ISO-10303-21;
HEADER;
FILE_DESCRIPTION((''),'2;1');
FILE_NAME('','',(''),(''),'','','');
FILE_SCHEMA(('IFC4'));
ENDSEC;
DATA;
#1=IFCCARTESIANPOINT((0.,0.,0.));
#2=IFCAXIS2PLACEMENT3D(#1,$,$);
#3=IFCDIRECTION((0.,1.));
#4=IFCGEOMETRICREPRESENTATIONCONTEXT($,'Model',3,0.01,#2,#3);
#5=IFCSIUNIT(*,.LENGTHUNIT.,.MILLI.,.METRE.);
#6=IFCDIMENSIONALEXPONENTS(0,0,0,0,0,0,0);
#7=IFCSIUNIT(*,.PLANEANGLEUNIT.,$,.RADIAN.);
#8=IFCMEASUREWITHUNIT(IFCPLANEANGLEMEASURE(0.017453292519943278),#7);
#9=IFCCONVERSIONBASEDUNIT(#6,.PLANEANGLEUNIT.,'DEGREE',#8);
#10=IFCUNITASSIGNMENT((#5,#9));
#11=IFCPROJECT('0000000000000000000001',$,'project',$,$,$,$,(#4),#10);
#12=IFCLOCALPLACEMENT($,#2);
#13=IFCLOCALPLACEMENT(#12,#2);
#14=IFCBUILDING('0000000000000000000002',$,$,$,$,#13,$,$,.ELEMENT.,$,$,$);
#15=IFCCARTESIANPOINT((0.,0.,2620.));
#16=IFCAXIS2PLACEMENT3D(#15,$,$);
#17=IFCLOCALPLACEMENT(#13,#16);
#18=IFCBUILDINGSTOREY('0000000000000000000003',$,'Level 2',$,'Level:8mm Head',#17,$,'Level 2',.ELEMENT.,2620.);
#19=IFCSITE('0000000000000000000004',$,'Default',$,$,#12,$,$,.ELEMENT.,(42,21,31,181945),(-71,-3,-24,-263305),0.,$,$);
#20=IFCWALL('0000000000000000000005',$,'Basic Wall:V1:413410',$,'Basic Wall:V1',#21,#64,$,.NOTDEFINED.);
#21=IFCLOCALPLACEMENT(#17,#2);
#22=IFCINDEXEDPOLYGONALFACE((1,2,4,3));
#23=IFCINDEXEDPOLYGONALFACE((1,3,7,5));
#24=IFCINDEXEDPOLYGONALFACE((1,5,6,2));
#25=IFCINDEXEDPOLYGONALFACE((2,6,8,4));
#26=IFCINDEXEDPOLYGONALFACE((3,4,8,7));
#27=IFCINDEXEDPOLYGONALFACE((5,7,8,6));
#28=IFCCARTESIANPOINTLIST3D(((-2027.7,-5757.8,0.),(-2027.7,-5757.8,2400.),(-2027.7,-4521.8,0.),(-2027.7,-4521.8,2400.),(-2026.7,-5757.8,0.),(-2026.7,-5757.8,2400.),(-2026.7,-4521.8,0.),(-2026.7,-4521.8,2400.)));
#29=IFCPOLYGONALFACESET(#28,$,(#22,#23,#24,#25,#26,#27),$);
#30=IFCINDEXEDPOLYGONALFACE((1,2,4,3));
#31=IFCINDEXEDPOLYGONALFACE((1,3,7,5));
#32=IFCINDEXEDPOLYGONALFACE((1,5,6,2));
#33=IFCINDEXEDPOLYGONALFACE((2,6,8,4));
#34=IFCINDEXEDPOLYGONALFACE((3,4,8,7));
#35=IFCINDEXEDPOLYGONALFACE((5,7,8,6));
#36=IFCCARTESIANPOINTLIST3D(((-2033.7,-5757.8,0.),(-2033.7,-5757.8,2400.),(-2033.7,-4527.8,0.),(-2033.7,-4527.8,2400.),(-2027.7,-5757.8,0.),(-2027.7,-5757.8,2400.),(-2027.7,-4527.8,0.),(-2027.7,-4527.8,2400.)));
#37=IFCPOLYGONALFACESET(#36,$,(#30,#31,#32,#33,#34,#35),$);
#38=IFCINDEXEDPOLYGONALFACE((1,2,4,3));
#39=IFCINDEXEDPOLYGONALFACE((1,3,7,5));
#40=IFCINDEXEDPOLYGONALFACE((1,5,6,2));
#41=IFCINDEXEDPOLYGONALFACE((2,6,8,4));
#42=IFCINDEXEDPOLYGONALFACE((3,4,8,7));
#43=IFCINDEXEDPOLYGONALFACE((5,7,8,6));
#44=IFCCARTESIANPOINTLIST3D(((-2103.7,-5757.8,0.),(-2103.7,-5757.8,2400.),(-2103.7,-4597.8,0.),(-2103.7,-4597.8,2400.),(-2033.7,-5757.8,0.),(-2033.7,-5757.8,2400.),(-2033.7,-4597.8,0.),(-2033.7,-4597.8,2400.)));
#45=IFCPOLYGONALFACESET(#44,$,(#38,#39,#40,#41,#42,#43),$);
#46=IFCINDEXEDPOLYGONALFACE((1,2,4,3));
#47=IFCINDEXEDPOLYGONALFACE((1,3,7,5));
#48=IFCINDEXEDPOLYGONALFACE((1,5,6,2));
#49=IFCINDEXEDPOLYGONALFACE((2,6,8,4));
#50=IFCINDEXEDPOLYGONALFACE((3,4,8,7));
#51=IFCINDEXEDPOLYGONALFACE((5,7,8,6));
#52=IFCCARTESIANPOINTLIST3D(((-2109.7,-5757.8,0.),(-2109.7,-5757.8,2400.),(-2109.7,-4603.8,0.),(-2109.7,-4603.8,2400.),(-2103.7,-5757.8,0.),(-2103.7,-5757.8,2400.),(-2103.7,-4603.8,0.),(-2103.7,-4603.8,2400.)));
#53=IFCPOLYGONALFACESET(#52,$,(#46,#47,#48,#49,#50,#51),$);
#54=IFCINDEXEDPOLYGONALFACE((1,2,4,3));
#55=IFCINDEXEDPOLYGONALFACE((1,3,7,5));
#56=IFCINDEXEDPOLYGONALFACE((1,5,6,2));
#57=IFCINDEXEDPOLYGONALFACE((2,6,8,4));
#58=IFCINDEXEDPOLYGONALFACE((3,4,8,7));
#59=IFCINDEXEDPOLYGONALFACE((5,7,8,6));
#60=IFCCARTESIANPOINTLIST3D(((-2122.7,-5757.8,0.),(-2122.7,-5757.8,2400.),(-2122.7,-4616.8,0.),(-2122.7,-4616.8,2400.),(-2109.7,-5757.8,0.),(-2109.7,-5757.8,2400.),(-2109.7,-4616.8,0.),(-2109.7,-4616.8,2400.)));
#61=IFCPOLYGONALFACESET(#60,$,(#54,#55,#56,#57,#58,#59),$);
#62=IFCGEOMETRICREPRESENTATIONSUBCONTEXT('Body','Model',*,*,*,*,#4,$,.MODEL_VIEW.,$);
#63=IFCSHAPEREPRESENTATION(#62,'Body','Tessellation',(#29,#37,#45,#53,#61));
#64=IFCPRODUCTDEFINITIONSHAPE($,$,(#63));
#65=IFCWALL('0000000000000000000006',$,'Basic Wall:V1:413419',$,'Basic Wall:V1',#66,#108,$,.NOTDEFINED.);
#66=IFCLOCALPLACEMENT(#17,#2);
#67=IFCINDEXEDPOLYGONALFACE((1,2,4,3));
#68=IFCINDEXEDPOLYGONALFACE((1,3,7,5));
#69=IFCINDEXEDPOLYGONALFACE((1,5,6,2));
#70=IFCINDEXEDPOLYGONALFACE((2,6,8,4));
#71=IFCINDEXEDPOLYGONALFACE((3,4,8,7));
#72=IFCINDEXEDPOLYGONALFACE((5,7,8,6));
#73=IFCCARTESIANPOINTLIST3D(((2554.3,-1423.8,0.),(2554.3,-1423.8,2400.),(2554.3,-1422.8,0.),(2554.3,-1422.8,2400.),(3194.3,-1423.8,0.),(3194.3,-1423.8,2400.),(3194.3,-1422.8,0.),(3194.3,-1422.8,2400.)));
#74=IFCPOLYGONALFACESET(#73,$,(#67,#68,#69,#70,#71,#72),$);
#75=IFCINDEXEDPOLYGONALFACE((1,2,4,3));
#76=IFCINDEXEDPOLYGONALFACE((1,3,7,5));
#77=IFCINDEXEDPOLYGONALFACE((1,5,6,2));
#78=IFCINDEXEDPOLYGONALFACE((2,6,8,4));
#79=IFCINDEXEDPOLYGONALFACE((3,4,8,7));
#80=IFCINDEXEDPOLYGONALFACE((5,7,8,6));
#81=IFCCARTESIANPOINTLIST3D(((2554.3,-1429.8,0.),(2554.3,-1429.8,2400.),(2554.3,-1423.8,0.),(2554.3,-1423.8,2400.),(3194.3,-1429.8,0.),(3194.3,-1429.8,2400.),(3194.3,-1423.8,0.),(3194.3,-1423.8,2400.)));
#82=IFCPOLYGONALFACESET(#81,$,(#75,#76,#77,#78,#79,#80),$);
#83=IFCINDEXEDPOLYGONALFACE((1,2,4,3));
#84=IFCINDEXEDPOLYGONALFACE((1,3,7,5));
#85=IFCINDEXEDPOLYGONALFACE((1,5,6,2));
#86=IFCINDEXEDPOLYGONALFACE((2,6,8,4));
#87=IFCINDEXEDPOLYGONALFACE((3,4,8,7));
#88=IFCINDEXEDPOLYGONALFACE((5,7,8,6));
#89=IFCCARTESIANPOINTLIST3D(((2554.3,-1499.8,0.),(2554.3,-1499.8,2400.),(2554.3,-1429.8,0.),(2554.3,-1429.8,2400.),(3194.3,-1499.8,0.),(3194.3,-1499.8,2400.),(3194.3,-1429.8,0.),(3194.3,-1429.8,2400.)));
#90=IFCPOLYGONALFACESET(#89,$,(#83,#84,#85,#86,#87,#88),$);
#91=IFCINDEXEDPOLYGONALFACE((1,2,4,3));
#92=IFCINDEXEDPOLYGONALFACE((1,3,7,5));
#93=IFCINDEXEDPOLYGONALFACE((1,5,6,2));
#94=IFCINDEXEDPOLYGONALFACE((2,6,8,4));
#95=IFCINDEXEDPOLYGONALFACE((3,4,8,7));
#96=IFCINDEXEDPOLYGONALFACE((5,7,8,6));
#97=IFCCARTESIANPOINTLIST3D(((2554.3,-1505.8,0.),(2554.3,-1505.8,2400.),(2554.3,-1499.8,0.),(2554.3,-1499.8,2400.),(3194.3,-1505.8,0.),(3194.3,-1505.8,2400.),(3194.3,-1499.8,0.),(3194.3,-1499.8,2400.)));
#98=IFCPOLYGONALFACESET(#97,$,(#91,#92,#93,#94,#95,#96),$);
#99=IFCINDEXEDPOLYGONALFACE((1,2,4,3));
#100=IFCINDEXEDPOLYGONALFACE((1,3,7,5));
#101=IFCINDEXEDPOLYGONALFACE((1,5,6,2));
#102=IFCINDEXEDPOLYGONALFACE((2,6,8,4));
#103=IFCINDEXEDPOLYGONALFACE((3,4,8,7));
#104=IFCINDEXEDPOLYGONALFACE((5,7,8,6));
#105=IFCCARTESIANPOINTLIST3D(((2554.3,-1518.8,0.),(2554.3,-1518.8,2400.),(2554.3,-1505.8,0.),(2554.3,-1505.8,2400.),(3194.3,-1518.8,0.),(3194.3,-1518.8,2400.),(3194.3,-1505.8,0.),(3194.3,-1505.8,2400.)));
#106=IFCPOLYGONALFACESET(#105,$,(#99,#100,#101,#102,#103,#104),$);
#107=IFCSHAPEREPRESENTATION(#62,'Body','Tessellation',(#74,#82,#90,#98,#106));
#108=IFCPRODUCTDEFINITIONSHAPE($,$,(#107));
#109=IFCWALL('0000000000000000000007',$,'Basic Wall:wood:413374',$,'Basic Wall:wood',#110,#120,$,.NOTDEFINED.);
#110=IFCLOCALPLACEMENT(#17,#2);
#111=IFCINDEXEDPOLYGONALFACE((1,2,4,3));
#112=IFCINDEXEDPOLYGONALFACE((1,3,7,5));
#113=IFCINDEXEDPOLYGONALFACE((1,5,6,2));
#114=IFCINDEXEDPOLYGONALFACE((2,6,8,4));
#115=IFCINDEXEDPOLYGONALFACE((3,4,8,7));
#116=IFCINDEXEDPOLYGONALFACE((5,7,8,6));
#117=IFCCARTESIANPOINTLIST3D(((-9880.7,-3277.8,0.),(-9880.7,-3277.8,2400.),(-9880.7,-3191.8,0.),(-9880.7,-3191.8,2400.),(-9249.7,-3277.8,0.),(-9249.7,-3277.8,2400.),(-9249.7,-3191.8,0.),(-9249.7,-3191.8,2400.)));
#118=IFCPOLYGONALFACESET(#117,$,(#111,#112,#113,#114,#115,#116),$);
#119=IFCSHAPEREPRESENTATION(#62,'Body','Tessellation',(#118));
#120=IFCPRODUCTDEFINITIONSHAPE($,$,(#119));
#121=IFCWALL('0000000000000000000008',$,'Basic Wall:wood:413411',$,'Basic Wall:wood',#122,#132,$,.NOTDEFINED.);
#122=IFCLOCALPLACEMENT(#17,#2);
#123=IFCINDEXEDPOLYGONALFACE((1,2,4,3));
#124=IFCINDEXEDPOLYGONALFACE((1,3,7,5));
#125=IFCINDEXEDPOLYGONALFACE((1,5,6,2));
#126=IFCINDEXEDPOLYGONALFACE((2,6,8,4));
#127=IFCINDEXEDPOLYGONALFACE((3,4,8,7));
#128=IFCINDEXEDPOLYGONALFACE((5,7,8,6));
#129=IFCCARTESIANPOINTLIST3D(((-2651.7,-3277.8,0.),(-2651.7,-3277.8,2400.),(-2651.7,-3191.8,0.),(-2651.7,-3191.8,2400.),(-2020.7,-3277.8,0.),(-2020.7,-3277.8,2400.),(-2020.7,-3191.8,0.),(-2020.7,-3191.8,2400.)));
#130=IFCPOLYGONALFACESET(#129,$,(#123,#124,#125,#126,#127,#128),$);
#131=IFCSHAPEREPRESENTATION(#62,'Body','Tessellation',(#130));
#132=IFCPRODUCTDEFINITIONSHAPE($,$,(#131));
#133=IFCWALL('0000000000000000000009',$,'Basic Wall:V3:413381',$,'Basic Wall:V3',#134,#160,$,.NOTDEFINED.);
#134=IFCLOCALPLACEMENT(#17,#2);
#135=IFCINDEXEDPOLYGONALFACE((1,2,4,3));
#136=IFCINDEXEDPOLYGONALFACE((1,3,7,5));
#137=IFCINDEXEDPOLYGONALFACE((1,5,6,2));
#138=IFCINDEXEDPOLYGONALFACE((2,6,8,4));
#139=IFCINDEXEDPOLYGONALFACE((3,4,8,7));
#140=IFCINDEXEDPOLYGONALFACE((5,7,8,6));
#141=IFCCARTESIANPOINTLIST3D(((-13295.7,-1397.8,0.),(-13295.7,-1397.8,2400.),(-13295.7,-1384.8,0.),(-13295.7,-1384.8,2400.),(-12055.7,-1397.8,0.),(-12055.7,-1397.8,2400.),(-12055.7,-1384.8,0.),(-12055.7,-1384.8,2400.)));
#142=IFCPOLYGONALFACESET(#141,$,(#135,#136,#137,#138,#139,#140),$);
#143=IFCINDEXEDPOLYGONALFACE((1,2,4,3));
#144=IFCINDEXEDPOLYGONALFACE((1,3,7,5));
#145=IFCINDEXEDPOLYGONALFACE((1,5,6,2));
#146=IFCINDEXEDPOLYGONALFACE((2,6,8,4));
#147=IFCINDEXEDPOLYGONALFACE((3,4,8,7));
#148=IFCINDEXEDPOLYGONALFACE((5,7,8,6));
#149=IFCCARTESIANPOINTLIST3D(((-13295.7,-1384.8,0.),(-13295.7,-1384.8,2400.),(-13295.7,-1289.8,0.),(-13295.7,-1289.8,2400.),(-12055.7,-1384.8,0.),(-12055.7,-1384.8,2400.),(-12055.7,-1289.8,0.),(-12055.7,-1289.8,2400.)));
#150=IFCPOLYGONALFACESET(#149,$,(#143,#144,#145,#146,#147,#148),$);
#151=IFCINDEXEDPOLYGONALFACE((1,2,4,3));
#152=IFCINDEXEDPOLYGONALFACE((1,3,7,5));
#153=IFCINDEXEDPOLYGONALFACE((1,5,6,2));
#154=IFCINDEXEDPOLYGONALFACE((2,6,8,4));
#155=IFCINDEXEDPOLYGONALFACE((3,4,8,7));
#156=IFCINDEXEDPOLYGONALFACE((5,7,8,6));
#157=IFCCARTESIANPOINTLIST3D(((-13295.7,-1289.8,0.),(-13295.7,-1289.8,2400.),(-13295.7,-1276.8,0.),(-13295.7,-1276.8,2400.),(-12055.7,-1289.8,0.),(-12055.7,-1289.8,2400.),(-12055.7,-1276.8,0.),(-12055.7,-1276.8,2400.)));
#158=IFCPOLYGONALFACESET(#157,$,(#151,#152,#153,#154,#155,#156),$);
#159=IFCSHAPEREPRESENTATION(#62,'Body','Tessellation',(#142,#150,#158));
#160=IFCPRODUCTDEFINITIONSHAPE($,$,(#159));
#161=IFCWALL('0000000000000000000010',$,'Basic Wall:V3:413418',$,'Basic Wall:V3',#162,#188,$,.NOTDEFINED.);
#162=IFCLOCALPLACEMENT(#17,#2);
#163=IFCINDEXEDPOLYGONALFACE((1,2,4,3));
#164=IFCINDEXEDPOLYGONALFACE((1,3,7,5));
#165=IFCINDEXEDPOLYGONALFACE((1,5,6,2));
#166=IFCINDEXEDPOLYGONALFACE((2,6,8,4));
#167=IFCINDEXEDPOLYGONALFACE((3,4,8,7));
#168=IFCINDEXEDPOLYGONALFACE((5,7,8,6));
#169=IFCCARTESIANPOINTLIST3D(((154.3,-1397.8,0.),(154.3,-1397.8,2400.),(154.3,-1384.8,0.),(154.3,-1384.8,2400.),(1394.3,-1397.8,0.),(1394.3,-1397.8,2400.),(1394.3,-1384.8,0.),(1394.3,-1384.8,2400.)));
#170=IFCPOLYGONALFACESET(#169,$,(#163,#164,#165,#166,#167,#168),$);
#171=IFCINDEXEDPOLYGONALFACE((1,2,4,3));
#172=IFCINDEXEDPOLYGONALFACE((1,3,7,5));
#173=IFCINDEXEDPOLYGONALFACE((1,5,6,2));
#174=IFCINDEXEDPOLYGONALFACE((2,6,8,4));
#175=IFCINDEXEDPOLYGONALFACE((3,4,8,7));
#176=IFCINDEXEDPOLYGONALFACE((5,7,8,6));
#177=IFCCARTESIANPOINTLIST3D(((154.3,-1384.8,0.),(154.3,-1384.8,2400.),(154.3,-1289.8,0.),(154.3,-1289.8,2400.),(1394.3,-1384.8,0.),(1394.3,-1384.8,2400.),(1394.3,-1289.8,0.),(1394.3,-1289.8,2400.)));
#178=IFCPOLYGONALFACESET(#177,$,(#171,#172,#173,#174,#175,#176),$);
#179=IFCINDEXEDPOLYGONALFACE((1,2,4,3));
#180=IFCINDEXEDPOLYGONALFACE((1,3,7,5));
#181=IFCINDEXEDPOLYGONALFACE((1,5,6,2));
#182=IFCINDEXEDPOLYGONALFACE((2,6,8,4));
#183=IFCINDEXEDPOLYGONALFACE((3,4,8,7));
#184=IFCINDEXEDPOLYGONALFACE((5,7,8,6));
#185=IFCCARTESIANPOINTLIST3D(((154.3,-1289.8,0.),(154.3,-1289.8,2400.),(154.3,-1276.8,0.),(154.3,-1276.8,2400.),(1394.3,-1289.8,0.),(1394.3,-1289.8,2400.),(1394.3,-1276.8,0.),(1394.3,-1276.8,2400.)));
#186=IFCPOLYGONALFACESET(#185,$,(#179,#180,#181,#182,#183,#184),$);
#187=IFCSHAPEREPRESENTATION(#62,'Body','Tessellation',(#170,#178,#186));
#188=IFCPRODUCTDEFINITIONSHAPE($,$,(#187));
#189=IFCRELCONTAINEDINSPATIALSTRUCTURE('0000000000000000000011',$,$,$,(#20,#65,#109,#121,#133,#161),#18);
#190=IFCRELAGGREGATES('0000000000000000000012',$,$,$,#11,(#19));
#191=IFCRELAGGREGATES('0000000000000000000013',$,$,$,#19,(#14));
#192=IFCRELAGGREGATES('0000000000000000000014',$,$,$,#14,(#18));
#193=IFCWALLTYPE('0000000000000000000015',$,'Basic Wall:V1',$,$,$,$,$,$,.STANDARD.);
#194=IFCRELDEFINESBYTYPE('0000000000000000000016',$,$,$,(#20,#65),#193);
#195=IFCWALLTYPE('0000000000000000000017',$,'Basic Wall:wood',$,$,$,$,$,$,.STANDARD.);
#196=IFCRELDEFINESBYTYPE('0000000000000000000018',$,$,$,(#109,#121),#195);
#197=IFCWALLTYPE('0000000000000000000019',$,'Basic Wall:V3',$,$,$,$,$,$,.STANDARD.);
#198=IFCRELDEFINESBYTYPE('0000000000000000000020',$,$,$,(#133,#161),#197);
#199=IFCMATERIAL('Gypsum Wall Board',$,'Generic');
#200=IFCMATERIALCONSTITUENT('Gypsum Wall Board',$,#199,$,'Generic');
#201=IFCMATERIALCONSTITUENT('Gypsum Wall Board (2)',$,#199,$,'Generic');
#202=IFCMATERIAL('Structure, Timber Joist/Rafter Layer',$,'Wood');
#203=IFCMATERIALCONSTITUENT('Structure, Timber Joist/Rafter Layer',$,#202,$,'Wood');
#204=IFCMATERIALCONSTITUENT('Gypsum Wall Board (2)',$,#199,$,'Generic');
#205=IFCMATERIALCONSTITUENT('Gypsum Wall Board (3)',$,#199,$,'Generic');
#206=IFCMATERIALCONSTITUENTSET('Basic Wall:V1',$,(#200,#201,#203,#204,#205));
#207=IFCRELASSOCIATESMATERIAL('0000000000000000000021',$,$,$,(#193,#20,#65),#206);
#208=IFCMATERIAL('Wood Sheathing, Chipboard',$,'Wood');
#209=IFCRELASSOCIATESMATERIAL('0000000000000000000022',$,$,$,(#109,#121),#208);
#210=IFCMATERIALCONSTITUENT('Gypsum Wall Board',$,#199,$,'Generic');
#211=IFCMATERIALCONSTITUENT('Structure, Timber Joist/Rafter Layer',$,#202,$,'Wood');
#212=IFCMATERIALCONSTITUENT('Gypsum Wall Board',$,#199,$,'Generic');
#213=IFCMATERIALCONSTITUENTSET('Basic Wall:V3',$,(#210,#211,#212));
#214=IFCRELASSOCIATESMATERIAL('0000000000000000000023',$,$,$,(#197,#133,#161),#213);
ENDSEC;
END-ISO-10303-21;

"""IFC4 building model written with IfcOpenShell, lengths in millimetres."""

from ifc_helpers import new_model, entity, si_unit, converted_unit, direction, frame, origin, place, context, subcontext, project, spatial, indexed_curve, outline, extrude, material, constituent, constituent_set, type_object, element, save


model = new_model("IFC4")

# Units and contexts
model_context = context("Model", 3, precision=0.01, world=origin(), true_north=direction((0.0, 1.0)))
body_context = subcontext(model_context, "Body", "Model", "MODEL_VIEW")
ifc_project = project(units=[si_unit("LENGTHUNIT", "METRE", prefix="MILLI"), converted_unit("PLANEANGLEUNIT", "DEGREE", entity("IfcPlaneAngleMeasure", 0.017453292519943278), si_unit("PLANEANGLEUNIT", "RADIAN"), dimensions=[0, 0, 0, 0, 0, 0, 0])], contexts=[model_context])

# Site, building, storey
site_placement = place(None, origin())
site = spatial("IfcSite", under=ifc_project, at=site_placement, Name="Default", CompositionType="ELEMENT", RefLatitude=(42, 21, 31, 181945), RefLongitude=(-71, -3, -24, -263305), RefElevation=0.0)
building_placement = place(site_placement, origin())
building = spatial("IfcBuilding", under=site, at=building_placement, CompositionType="ELEMENT")
storey_placement = place(building_placement, frame((0.0, 0.0, 2620.0)))
storey = spatial("IfcBuildingStorey", under=building, at=storey_placement, Name="Level 2", ObjectType="Level:8mm Head", LongName="Level 2", CompositionType="ELEMENT", Elevation=2620.0)

# Walls
ifc_material_1 = material(Name="Gypsum Wall Board", Category="Generic")
ifc_constituent_1 = constituent(ifc_material_1, Name="Gypsum Wall Board", Category="Generic")
ifc_constituent_2 = constituent(ifc_material_1, Name="Gypsum Wall Board (2)", Category="Generic")
ifc_material_2 = material(Name="Structure, Timber Joist/Rafter Layer", Category="Wood")
ifc_constituent_3 = constituent(ifc_material_2, Name="Structure, Timber Joist/Rafter Layer", Category="Wood")
ifc_constituent_4 = constituent(ifc_material_1, Name="Gypsum Wall Board (2)", Category="Generic")
ifc_constituent_5 = constituent(ifc_material_1, Name="Gypsum Wall Board (3)", Category="Generic")
ifc_constituent_set_1 = constituent_set(constituents=[ifc_constituent_1, ifc_constituent_2, ifc_constituent_3, ifc_constituent_4, ifc_constituent_5], Name="Basic Wall:V1")
wall_type_1 = type_object("IfcWallType", Name="Basic Wall:V1", PredefinedType="STANDARD", material=ifc_constituent_set_1)
wall_1_placement = place(storey_placement, frame((-2074.7, -4616.8, 0.0), z_axis=(0.0, 0.0, 1.0), x_axis=(0.0, -1.0, 0.0)))
element("IfcWall", 1, at=wall_1_placement, inside=storey, type_object=wall_type_1, material=ifc_constituent_set_1, Name="Basic Wall:V1:413410", ObjectType="Basic Wall:V1", PredefinedType="NOTDEFINED", context=body_context, shape_type="SweptSolid", body=[
    extrude(outline(indexed_curve([(-0.5, -618.0), (0.5, -618.0), (0.5, 618.0), (-0.5, 618.0), (-0.5, -618.0)], self_intersect=False)), frame((523.0, 47.5, 0.0), z_axis=(0.0, 0.0, 1.0), x_axis=(0.0, -1.0, 0.0)), (0.0, 0.0, 1.0), 2400.0),
    extrude(outline(indexed_curve([(-615.0, -3.0), (615.0, -3.0), (615.0, 3.0), (-615.0, 3.0), (-615.0, -3.0)], self_intersect=False)), frame((526.0, 44.0, 0.0)), (0.0, 0.0, 1.0), 2400.0),
    extrude(outline(indexed_curve([(-580.0, -35.0), (580.0, -35.0), (580.0, 35.0), (-580.0, 35.0), (-580.0, -35.0)], self_intersect=False)), frame((561.0, 6.0, 0.0)), (0.0, 0.0, 1.0), 2400.0),
    extrude(outline(indexed_curve([(-577.0, -3.0), (577.0, -3.0), (577.0, 3.0), (-577.0, 3.0), (-577.0, -3.0)], self_intersect=False)), frame((564.0, -32.0, 0.0)), (0.0, 0.0, 1.0), 2400.0),
    extrude(outline(indexed_curve([(-6.5, -570.5), (6.5, -570.5), (6.5, 570.5), (-6.5, 570.5), (-6.5, -570.5)], self_intersect=False)), frame((570.5, -41.5, 0.0), z_axis=(0.0, 0.0, 1.0), x_axis=(0.0, 1.0, 0.0)), (0.0, 0.0, 1.0), 2400.0),
])
wall_2_placement = place(storey_placement, frame((2554.3, -1470.8, 0.0)))
element("IfcWall", 2, at=wall_2_placement, inside=storey, type_object=wall_type_1, material=ifc_constituent_set_1, Name="Basic Wall:V1:413419", ObjectType="Basic Wall:V1", PredefinedType="NOTDEFINED", context=body_context, shape_type="SweptSolid", body=[
    extrude(outline(indexed_curve([(-0.5, -320.0), (0.5, -320.0), (0.5, 320.0), (-0.5, 320.0), (-0.5, -320.0)], self_intersect=False)), frame((320.0, 47.5, 0.0), z_axis=(0.0, 0.0, 1.0), x_axis=(0.0, -1.0, 0.0)), (0.0, 0.0, 1.0), 2400.0),
    extrude(outline(indexed_curve([(-320.0, -3.0), (320.0, -3.0), (320.0, 3.0), (-320.0, 3.0), (-320.0, -3.0)], self_intersect=False)), frame((320.0, 44.0, 0.0)), (0.0, 0.0, 1.0), 2400.0),
    extrude(outline(indexed_curve([(-320.0, -35.0), (320.0, -35.0), (320.0, 35.0), (-320.0, 35.0), (-320.0, -35.0)], self_intersect=False)), frame((320.0, 6.0, 0.0)), (0.0, 0.0, 1.0), 2400.0),
    extrude(outline(indexed_curve([(-320.0, -3.0), (320.0, -3.0), (320.0, 3.0), (-320.0, 3.0), (-320.0, -3.0)], self_intersect=False)), frame((320.0, -32.0, 0.0)), (0.0, 0.0, 1.0), 2400.0),
    extrude(outline(indexed_curve([(-6.5, -320.0), (6.5, -320.0), (6.5, 320.0), (-6.5, 320.0), (-6.5, -320.0)], self_intersect=False)), frame((320.0, -41.5, 0.0), z_axis=(0.0, 0.0, 1.0), x_axis=(0.0, 1.0, 0.0)), (0.0, 0.0, 1.0), 2400.0),
])
ifc_material_3 = material(Name="Wood Sheathing, Chipboard", Category="Wood")
wall_type_2 = type_object("IfcWallType", Name="Basic Wall:wood", PredefinedType="STANDARD")
wall_3_placement = place(storey_placement, frame((-9249.7, -3234.8, 0.0), z_axis=(0.0, 0.0, 1.0), x_axis=(-1.0, 0.0, 0.0)))
element("IfcWall", 3, at=wall_3_placement, inside=storey, type_object=wall_type_2, material=ifc_material_3, Name="Basic Wall:wood:413374", ObjectType="Basic Wall:wood", PredefinedType="NOTDEFINED", context=body_context, shape_type="SweptSolid", body=[
    extrude(outline(indexed_curve([(631.0, 43.0), (0.0, 43.0), (0.0, -43.0), (631.0, -43.0), (631.0, 43.0)], self_intersect=False)), origin(), (0.0, 0.0, 1.0), 2400.0),
])
wall_4_placement = place(storey_placement, frame((-2651.7, -3234.8, 0.0)))
element("IfcWall", 4, at=wall_4_placement, inside=storey, type_object=wall_type_2, material=ifc_material_3, Name="Basic Wall:wood:413411", ObjectType="Basic Wall:wood", PredefinedType="NOTDEFINED", context=body_context, shape_type="SweptSolid", body=[
    extrude(outline(indexed_curve([(631.0, 43.0), (0.0, 43.0), (0.0, -43.0), (631.0, -43.0), (631.0, 43.0)], self_intersect=False)), origin(), (0.0, 0.0, 1.0), 2400.0),
])

# Walls
ifc_constituent_6 = constituent(ifc_material_1, Name="Gypsum Wall Board", Category="Generic")
ifc_constituent_7 = constituent(ifc_material_2, Name="Structure, Timber Joist/Rafter Layer", Category="Wood")
ifc_constituent_8 = constituent(ifc_material_1, Name="Gypsum Wall Board", Category="Generic")
ifc_constituent_set_2 = constituent_set(constituents=[ifc_constituent_6, ifc_constituent_7, ifc_constituent_8], Name="Basic Wall:V3")
wall_type_3 = type_object("IfcWallType", Name="Basic Wall:V3", PredefinedType="STANDARD", material=ifc_constituent_set_2)
wall_5_placement = place(storey_placement, frame((-12055.7, -1337.3, 0.0), z_axis=(0.0, 0.0, 1.0), x_axis=(-1.0, 0.0, 0.0)))
element("IfcWall", 5, at=wall_5_placement, inside=storey, type_object=wall_type_3, material=ifc_constituent_set_2, Name="Basic Wall:V3:413381", ObjectType="Basic Wall:V3", PredefinedType="NOTDEFINED", context=body_context, shape_type="SweptSolid", body=[
    extrude(outline(indexed_curve([(-6.5, -620.0), (6.5, -620.0), (6.5, 620.0), (-6.5, 620.0), (-6.5, -620.0)], self_intersect=False)), frame((620.0, 54.0, 0.0), z_axis=(0.0, 0.0, 1.0), x_axis=(0.0, -1.0, 0.0)), (0.0, 0.0, 1.0), 2400.0),
    extrude(outline(indexed_curve([(-620.0, -47.5), (620.0, -47.5), (620.0, 47.5), (-620.0, 47.5), (-620.0, -47.5)], self_intersect=False)), frame((620.0, 0.0, 0.0)), (0.0, 0.0, 1.0), 2400.0),
    extrude(outline(indexed_curve([(-6.5, -620.0), (6.5, -620.0), (6.5, 620.0), (-6.5, 620.0), (-6.5, -620.0)], self_intersect=False)), frame((620.0, -54.0, 0.0), z_axis=(0.0, 0.0, 1.0), x_axis=(0.0, 1.0, 0.0)), (0.0, 0.0, 1.0), 2400.0),
])
wall_6_placement = place(storey_placement, frame((154.3, -1337.3, 0.0)))
element("IfcWall", 6, at=wall_6_placement, inside=storey, type_object=wall_type_3, material=ifc_constituent_set_2, Name="Basic Wall:V3:413418", ObjectType="Basic Wall:V3", PredefinedType="NOTDEFINED", context=body_context, shape_type="SweptSolid", body=[
    extrude(outline(indexed_curve([(-6.5, -620.0), (6.5, -620.0), (6.5, 620.0), (-6.5, 620.0), (-6.5, -620.0)], self_intersect=False)), frame((620.0, -54.0, 0.0), z_axis=(0.0, 0.0, 1.0), x_axis=(0.0, 1.0, 0.0)), (0.0, 0.0, 1.0), 2400.0),
    extrude(outline(indexed_curve([(-620.0, -47.5), (620.0, -47.5), (620.0, 47.5), (-620.0, 47.5), (-620.0, -47.5)], self_intersect=False)), frame((620.0, 0.0, 0.0)), (0.0, 0.0, 1.0), 2400.0),
    extrude(outline(indexed_curve([(-6.5, -620.0), (6.5, -620.0), (6.5, 620.0), (-6.5, 620.0), (-6.5, -620.0)], self_intersect=False)), frame((620.0, 54.0, 0.0), z_axis=(0.0, 0.0, 1.0), x_axis=(0.0, -1.0, 0.0)), (0.0, 0.0, 1.0), 2400.0),
])

save(model, "model.ifc")
